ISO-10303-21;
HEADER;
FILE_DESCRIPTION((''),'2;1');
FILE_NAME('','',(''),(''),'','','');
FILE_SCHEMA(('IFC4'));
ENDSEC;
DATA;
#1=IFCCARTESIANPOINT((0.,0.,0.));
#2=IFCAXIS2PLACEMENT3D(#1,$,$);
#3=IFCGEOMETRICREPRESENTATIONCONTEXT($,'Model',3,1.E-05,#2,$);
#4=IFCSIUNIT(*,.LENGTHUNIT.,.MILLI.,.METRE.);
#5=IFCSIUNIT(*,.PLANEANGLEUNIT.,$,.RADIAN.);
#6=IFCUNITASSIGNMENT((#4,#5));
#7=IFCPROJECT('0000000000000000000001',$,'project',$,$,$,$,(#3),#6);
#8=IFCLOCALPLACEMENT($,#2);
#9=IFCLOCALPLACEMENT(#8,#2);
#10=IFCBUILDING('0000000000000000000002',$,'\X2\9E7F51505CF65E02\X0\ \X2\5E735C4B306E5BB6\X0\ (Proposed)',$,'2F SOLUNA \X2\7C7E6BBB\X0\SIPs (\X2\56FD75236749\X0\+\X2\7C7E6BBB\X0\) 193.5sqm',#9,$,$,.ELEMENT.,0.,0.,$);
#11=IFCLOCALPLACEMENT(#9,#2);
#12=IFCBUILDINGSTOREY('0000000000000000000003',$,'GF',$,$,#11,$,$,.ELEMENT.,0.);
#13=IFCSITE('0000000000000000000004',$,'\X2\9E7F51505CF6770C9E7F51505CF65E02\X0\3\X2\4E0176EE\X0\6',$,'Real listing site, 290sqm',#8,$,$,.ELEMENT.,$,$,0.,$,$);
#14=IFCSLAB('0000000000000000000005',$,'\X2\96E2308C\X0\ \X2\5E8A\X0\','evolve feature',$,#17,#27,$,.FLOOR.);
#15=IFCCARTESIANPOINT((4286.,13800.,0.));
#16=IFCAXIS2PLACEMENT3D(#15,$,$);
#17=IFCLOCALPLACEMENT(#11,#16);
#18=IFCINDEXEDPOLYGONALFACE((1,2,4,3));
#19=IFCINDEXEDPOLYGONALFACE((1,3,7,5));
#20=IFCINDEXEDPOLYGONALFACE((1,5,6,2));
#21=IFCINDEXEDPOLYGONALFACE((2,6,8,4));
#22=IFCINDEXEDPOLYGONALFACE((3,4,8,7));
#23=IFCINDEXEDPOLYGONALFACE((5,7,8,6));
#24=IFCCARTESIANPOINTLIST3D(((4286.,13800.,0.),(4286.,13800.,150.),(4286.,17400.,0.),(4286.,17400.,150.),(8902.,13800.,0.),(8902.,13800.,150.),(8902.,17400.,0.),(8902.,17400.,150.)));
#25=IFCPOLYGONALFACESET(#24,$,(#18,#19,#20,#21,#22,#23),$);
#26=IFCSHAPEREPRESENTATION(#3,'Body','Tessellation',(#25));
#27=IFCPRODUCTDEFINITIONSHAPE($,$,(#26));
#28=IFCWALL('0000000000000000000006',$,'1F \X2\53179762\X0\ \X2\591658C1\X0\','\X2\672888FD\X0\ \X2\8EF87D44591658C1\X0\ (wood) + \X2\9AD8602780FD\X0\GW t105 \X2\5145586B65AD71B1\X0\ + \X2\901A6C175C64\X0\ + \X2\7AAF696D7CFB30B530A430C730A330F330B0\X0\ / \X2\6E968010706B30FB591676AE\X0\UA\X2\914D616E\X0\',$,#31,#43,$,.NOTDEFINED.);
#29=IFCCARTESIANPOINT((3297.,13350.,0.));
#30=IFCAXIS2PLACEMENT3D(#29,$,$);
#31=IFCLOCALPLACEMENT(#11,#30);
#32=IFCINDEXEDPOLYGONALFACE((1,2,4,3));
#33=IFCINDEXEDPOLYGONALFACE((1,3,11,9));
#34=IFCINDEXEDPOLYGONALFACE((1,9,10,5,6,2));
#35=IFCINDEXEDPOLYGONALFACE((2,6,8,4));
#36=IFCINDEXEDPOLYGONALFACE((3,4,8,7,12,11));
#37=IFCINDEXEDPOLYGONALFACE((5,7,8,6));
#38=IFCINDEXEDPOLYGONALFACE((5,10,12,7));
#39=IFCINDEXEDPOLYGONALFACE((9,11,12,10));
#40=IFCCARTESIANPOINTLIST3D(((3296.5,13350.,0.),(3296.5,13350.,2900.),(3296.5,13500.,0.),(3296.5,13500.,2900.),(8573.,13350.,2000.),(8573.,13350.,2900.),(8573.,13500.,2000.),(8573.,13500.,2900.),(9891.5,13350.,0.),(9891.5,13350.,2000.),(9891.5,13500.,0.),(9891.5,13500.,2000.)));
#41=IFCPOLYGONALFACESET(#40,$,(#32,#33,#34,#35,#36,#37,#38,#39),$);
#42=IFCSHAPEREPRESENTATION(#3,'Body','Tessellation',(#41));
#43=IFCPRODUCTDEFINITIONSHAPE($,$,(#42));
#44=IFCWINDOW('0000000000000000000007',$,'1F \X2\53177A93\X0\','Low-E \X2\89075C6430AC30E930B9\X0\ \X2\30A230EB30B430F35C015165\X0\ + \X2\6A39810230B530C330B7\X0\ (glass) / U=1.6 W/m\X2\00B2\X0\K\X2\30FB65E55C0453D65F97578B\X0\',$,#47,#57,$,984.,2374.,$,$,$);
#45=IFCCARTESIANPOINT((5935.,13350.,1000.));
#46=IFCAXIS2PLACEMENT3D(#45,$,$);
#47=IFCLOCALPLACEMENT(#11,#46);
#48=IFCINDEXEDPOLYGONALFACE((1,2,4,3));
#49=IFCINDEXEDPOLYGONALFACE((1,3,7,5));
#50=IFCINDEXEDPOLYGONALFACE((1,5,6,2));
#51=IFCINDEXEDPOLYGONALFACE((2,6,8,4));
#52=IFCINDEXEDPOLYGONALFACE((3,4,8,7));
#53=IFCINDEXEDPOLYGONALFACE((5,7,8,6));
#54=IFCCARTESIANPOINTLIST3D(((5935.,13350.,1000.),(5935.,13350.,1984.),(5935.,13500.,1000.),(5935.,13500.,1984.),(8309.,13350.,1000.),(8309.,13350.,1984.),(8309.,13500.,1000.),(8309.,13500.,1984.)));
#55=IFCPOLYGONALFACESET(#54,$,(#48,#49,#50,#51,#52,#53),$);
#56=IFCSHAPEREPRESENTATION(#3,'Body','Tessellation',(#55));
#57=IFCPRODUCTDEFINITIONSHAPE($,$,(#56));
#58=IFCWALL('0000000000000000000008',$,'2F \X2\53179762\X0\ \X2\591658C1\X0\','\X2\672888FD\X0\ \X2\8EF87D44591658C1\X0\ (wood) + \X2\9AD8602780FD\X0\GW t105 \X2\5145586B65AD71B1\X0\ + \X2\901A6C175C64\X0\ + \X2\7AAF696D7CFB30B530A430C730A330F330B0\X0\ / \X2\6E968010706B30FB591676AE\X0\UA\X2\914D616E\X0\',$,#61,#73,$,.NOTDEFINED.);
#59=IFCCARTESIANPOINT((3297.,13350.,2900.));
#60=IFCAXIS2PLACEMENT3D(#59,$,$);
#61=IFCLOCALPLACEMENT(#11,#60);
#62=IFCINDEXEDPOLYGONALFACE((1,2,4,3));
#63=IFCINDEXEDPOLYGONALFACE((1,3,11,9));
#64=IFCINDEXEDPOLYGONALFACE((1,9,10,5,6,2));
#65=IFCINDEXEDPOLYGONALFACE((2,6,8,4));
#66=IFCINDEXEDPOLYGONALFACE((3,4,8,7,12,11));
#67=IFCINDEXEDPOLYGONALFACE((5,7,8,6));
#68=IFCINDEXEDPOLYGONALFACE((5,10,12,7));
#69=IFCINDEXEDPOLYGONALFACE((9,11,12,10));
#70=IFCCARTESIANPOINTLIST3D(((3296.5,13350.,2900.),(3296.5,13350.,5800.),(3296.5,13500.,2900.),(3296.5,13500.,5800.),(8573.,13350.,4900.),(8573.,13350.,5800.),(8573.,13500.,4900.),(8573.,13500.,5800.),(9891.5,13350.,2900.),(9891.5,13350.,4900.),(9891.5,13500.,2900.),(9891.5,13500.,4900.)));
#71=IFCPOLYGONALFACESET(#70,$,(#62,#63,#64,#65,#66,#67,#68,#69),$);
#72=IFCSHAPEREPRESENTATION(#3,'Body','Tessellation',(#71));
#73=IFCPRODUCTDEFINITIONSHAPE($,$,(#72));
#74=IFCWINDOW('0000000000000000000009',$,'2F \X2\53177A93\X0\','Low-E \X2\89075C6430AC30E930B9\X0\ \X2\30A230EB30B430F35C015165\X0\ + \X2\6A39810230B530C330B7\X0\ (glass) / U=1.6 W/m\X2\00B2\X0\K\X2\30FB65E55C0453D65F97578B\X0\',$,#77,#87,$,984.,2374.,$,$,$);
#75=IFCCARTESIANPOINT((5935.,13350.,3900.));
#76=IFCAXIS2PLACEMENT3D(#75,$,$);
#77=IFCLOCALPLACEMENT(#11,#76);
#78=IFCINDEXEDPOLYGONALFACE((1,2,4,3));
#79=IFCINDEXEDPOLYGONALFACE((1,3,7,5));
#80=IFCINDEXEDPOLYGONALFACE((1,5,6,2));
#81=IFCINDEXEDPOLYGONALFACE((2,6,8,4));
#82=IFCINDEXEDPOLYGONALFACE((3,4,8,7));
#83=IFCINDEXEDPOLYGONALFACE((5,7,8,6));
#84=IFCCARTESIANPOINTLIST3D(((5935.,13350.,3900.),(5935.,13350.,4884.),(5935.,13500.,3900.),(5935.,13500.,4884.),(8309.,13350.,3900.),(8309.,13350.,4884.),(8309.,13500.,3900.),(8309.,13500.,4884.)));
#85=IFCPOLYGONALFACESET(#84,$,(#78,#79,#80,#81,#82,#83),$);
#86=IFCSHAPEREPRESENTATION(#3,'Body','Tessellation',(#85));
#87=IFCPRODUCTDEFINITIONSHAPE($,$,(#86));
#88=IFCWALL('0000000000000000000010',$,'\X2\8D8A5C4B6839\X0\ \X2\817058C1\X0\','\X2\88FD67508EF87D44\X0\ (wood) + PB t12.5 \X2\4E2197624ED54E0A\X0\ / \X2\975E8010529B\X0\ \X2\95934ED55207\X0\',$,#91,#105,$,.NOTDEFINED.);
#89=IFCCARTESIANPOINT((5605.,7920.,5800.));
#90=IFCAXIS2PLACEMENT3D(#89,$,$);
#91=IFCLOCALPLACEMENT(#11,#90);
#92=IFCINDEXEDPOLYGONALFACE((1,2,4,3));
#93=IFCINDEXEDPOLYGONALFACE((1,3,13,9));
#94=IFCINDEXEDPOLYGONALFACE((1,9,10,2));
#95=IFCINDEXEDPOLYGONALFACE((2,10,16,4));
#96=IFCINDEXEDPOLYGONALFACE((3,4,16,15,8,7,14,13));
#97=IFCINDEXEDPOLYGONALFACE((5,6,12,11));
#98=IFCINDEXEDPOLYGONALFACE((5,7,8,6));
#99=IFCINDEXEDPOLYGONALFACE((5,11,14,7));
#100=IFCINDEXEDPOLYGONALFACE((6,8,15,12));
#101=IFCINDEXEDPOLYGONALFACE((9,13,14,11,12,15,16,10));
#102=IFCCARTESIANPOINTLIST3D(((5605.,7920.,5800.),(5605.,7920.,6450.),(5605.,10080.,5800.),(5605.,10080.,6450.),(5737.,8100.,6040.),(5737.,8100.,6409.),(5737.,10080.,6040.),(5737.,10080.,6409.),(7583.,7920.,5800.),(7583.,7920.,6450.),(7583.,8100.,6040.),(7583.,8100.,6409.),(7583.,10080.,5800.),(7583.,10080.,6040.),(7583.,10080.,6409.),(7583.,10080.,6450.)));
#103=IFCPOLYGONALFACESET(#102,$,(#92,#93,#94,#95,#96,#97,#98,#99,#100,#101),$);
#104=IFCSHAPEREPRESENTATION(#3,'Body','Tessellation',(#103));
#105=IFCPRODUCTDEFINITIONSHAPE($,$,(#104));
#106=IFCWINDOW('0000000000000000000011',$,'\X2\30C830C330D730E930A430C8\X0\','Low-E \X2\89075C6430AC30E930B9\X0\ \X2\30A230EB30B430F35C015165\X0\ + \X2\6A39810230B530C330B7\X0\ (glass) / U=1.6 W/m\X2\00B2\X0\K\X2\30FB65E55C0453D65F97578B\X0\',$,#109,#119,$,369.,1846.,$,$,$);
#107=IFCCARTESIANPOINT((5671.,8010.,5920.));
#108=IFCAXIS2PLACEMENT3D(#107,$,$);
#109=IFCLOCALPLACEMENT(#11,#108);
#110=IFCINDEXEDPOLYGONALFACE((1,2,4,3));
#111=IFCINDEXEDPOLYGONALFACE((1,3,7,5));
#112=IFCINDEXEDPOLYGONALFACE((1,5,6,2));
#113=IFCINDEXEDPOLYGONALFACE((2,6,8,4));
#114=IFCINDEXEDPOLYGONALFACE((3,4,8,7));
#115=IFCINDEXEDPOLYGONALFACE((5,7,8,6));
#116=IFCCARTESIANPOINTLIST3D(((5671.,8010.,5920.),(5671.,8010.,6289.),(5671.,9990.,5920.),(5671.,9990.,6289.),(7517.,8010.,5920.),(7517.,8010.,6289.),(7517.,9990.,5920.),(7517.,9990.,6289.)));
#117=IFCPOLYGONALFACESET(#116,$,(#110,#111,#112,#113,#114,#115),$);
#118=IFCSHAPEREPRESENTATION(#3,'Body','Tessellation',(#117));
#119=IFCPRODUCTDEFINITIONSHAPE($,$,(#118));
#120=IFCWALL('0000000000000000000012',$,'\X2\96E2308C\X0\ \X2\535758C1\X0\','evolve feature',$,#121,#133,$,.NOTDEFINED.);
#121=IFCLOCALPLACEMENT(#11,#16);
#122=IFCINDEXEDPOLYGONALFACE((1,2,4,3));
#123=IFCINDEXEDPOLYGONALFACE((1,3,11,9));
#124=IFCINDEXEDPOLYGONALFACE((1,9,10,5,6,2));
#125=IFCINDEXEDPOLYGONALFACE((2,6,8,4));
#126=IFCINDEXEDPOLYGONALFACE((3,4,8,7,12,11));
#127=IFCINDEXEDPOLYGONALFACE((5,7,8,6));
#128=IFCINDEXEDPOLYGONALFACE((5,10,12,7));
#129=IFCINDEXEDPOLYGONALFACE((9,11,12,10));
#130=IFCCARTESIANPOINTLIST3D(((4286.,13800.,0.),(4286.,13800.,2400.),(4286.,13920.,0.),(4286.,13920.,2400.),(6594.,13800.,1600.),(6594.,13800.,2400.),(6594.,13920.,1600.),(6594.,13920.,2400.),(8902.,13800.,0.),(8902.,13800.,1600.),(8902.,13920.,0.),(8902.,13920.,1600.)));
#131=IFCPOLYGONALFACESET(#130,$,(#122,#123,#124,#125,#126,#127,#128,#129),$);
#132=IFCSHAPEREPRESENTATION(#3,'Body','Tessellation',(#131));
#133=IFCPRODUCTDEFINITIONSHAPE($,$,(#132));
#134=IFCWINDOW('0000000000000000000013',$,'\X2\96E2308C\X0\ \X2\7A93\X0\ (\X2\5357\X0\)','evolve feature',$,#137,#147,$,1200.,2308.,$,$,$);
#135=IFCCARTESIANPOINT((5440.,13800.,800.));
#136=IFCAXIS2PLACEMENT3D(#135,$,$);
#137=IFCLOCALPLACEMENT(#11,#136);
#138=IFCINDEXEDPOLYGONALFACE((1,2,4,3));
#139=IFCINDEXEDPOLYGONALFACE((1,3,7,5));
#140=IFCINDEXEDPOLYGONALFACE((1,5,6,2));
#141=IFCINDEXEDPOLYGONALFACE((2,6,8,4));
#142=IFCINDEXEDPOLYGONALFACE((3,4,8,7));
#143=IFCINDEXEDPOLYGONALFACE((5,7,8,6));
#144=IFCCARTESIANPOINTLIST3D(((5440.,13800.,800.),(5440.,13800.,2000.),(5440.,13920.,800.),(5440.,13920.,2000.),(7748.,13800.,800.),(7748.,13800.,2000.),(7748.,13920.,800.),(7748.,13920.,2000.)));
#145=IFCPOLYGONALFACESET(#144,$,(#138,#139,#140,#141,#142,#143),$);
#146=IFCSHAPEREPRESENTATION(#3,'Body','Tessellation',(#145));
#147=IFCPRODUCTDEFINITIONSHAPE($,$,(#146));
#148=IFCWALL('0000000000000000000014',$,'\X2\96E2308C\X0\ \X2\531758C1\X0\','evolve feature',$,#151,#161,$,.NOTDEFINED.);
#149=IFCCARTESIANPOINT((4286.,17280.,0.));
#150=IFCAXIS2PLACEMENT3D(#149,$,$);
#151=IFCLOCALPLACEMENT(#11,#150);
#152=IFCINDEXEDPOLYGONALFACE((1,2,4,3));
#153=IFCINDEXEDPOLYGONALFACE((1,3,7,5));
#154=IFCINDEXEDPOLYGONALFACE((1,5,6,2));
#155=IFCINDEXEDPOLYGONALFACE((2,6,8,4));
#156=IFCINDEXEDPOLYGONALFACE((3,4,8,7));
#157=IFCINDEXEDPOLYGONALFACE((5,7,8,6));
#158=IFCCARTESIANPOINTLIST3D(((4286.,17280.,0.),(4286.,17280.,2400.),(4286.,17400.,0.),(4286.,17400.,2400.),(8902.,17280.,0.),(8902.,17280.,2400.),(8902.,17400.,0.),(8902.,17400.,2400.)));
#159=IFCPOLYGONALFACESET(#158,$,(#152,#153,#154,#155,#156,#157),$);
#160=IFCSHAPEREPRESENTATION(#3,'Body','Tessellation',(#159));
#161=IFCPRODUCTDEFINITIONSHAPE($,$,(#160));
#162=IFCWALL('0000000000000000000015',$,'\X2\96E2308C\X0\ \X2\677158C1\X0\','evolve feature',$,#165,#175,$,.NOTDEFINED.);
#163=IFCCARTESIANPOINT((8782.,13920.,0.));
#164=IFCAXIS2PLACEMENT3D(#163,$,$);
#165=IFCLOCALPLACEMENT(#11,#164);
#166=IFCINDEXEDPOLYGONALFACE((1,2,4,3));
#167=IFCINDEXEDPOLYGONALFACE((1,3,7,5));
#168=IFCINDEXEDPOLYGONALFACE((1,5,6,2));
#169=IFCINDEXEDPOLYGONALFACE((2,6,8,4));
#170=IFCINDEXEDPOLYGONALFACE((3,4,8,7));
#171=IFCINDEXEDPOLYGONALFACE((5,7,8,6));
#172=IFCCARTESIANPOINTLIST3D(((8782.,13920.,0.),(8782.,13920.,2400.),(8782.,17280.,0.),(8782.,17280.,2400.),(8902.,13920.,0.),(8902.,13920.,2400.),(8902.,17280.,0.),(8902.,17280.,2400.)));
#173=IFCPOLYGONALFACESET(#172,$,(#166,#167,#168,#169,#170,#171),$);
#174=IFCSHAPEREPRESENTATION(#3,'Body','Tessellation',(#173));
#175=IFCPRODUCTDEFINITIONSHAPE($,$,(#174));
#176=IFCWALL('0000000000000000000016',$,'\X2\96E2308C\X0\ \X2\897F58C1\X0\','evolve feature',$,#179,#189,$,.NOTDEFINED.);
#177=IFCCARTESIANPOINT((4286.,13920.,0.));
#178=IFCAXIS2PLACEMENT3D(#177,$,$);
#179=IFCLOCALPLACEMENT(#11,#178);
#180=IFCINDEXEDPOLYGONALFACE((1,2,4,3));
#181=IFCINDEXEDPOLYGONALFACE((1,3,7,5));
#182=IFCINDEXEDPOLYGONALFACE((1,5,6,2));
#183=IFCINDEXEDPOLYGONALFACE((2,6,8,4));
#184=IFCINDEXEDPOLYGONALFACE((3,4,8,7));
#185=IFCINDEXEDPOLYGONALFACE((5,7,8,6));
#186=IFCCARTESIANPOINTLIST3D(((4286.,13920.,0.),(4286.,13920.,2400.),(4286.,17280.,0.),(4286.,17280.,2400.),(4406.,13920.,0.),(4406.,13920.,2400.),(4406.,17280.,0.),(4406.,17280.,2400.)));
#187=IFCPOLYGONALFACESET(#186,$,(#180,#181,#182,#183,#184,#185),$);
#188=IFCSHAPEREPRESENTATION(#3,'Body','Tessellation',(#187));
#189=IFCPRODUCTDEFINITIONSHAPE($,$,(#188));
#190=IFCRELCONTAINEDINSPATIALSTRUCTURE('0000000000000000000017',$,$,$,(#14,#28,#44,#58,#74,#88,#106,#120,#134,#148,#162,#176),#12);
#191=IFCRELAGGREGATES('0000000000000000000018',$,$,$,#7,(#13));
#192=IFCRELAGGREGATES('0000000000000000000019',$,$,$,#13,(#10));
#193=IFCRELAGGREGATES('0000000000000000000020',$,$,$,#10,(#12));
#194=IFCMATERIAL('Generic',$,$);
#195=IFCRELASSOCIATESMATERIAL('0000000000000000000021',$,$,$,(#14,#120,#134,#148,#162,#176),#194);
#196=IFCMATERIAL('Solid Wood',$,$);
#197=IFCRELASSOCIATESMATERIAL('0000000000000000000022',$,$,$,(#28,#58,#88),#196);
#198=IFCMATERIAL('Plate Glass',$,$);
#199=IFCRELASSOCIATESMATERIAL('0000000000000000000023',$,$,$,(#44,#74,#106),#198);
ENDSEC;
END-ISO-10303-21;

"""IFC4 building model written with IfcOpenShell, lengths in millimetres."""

from ifc_helpers import new_model, si_unit, frame, frame_2d, origin, place, context, project, spatial, rectangle, extrude, material, element, fill, save


model = new_model("IFC4")

# Units and contexts
model_context = context("Model", 3, precision=1e-05, world=origin())
ifc_project = project(units=[si_unit("LENGTHUNIT", "METRE", prefix="MILLI"), si_unit("PLANEANGLEUNIT", "RADIAN")], contexts=[model_context])

# Site, building, storey
site_placement = place(None, origin())
site = spatial("IfcSite", under=ifc_project, at=site_placement, Name="鹿児島県鹿児島市3丁目6", ObjectType="Real listing site, 290sqm", CompositionType="ELEMENT", RefElevation=0.0)
building_placement = place(site_placement, origin())
building = spatial("IfcBuilding", under=site, at=building_placement, Name="鹿児島市 平屋の家 (Proposed)", ObjectType="2F SOLUNA 籾殻SIPs (国産杉+籾殻) 193.5sqm", CompositionType="ELEMENT", ElevationOfRefHeight=0.0, ElevationOfTerrain=0.0)
storey_placement = place(building_placement, origin())
storey = spatial("IfcBuildingStorey", under=building, at=storey_placement, Name="GF", CompositionType="ELEMENT", Elevation=0.0)

# Slab
ifc_material_1 = material(Name="Generic")
slab_placement = place(storey_placement, frame((4286.0, 13800.0, 0.0)))
element("IfcSlab", 1, at=slab_placement, inside=storey, material=ifc_material_1, Name="離れ 床", Description="evolve feature", PredefinedType="FLOOR", context=model_context, shape_type="SweptSolid", body=[
    extrude(rectangle(XDim=4616.0, YDim=3600.0, at=frame_2d((2308.0, 1800.0))), frame((4286.0, 13800.0, 0.0)), (0.0, 0.0, 1.0), 150.0),
])

# Wall, opening, window
ifc_material_2 = material(Name="Solid Wood")
wall_1_placement = place(storey_placement, frame((3297.0, 13350.0, 0.0)))
wall_1 = element("IfcWall", 2, at=wall_1_placement, inside=storey, material=ifc_material_2, Name="1F 北面 外壁", Description="木製 軸組外壁 (wood) + 高性能GW t105 充填断熱 + 通気層 + 窯業系サイディング / 準耐火・外皮UA配慮", PredefinedType="NOTDEFINED", context=model_context, shape_type="SweptSolid", body=[
    extrude(rectangle(XDim=6595.0, YDim=150.0, at=frame_2d((3297.0, 75.0))), frame((3297.0, 13350.0, 0.0)), (0.0, 0.0, 1.0), 2900.0),
])
opening_1_placement = place(storey_placement, frame((5935.0, 13350.0, 1000.0)))
opening_1 = element("IfcOpeningElement", 3, at=opening_1_placement, cuts=wall_1, PredefinedType="NOTDEFINED", context=model_context, shape_type="SweptSolid", body=[
    extrude(rectangle(XDim=2374.0, YDim=150.0, at=frame_2d((1187.0, 75.0))), frame((5935.0, 13350.0, 1000.0)), (0.0, 0.0, 1.0), 984.0),
])
ifc_material_3 = material(Name="Plate Glass")
window_1_placement = place(storey_placement, frame((5935.0, 13350.0, 1000.0)))
window_1 = element("IfcWindow", 4, at=window_1_placement, inside=storey, material=ifc_material_3, Name="1F 北窓", Description="Low-E 複層ガラス アルゴン封入 + 樹脂サッシ (glass) / U=1.6 W/m²K・日射取得型", OverallHeight=984.0, OverallWidth=2374.0, context=model_context, shape_type="SweptSolid", body=[
    extrude(rectangle(XDim=2374.0, YDim=150.0, at=frame_2d((1187.0, 75.0))), frame((5935.0, 13350.0, 1000.0)), (0.0, 0.0, 1.0), 984.0),
])
fill(opening_1, window_1)

# Wall, opening, window
wall_2_placement = place(storey_placement, frame((3297.0, 13350.0, 2900.0)))
wall_2 = element("IfcWall", 5, at=wall_2_placement, inside=storey, material=ifc_material_2, Name="2F 北面 外壁", Description="木製 軸組外壁 (wood) + 高性能GW t105 充填断熱 + 通気層 + 窯業系サイディング / 準耐火・外皮UA配慮", PredefinedType="NOTDEFINED", context=model_context, shape_type="SweptSolid", body=[
    extrude(rectangle(XDim=6595.0, YDim=150.0, at=frame_2d((3297.0, 75.0))), frame((3297.0, 13350.0, 2900.0)), (0.0, 0.0, 1.0), 2900.0),
])
opening_2_placement = place(storey_placement, frame((5935.0, 13350.0, 3900.0)))
opening_2 = element("IfcOpeningElement", 6, at=opening_2_placement, cuts=wall_2, PredefinedType="NOTDEFINED", context=model_context, shape_type="SweptSolid", body=[
    extrude(rectangle(XDim=2374.0, YDim=150.0, at=frame_2d((1187.0, 75.0))), frame((5935.0, 13350.0, 3900.0)), (0.0, 0.0, 1.0), 984.0),
])
window_2_placement = place(storey_placement, frame((5935.0, 13350.0, 3900.0)))
window_2 = element("IfcWindow", 7, at=window_2_placement, inside=storey, material=ifc_material_3, Name="2F 北窓", Description="Low-E 複層ガラス アルゴン封入 + 樹脂サッシ (glass) / U=1.6 W/m²K・日射取得型", OverallHeight=984.0, OverallWidth=2374.0, context=model_context, shape_type="SweptSolid", body=[
    extrude(rectangle(XDim=2374.0, YDim=150.0, at=frame_2d((1187.0, 75.0))), frame((5935.0, 13350.0, 3900.0)), (0.0, 0.0, 1.0), 984.0),
])
fill(opening_2, window_2)

# Walls, openings, windows
wall_3_placement = place(storey_placement, frame((5605.0, 7920.0, 5800.0)))
wall_3 = element("IfcWall", 8, at=wall_3_placement, inside=storey, material=ifc_material_2, Name="越屋根 腰壁", Description="製材軸組 (wood) + PB t12.5 両面仕上 / 非耐力 間仕切", PredefinedType="NOTDEFINED", context=model_context, shape_type="SweptSolid", body=[
    extrude(rectangle(XDim=1978.0, YDim=2160.0, at=frame_2d((989.0, 1080.0))), frame((5605.0, 7920.0, 5800.0)), (0.0, 0.0, 1.0), 650.0),
])
opening_3_placement = place(storey_placement, frame((5671.0, 8010.0, 5920.0)))
opening_3 = element("IfcOpeningElement", 9, at=opening_3_placement, cuts=wall_3, PredefinedType="NOTDEFINED", context=model_context, shape_type="SweptSolid", body=[
    extrude(rectangle(XDim=1846.0, YDim=1980.0, at=frame_2d((923.0, 990.0))), frame((5671.0, 8010.0, 5920.0)), (0.0, 0.0, 1.0), 369.0),
])
window_3_placement = place(storey_placement, frame((5671.0, 8010.0, 5920.0)))
window_3 = element("IfcWindow", 10, at=window_3_placement, inside=storey, material=ifc_material_3, Name="トップライト", Description="Low-E 複層ガラス アルゴン封入 + 樹脂サッシ (glass) / U=1.6 W/m²K・日射取得型", OverallHeight=369.0, OverallWidth=1846.0, context=model_context, shape_type="SweptSolid", body=[
    extrude(rectangle(XDim=1846.0, YDim=1980.0, at=frame_2d((923.0, 990.0))), frame((5671.0, 8010.0, 5920.0)), (0.0, 0.0, 1.0), 369.0),
])
fill(opening_3, window_3)
wall_4_placement = place(storey_placement, frame((4286.0, 13800.0, 0.0)))
wall_4 = element("IfcWall", 11, at=wall_4_placement, inside=storey, material=ifc_material_1, Name="離れ 南壁", Description="evolve feature", PredefinedType="NOTDEFINED", context=model_context, shape_type="SweptSolid", body=[
    extrude(rectangle(XDim=4616.0, YDim=120.0, at=frame_2d((2308.0, 60.0))), frame((4286.0, 13800.0, 0.0)), (0.0, 0.0, 1.0), 2400.0),
])
opening_4_placement = place(storey_placement, frame((5440.0, 13800.0, 800.0)))
opening_4 = element("IfcOpeningElement", 12, at=opening_4_placement, cuts=wall_4, PredefinedType="NOTDEFINED", context=model_context, shape_type="SweptSolid", body=[
    extrude(rectangle(XDim=2308.0, YDim=120.0, at=frame_2d((1154.0, 60.0))), frame((5440.0, 13800.0, 800.0)), (0.0, 0.0, 1.0), 1200.0),
])
window_4_placement = place(storey_placement, frame((5440.0, 13800.0, 800.0)))
window_4 = element("IfcWindow", 13, at=window_4_placement, inside=storey, material=ifc_material_1, Name="離れ 窓 (南)", Description="evolve feature", OverallHeight=1200.0, OverallWidth=2308.0, context=model_context, shape_type="SweptSolid", body=[
    extrude(rectangle(XDim=2308.0, YDim=120.0, at=frame_2d((1154.0, 60.0))), frame((5440.0, 13800.0, 800.0)), (0.0, 0.0, 1.0), 1200.0),
])
fill(opening_4, window_4)

# Walls
wall_5_placement = place(storey_placement, frame((4286.0, 17280.0, 0.0)))
element("IfcWall", 14, at=wall_5_placement, inside=storey, material=ifc_material_1, Name="離れ 北壁", Description="evolve feature", PredefinedType="NOTDEFINED", context=model_context, shape_type="SweptSolid", body=[
    extrude(rectangle(XDim=4616.0, YDim=120.0, at=frame_2d((2308.0, 60.0))), frame((4286.0, 17280.0, 0.0)), (0.0, 0.0, 1.0), 2400.0),
])
wall_6_placement = place(storey_placement, frame((8782.0, 13920.0, 0.0)))
element("IfcWall", 15, at=wall_6_placement, inside=storey, material=ifc_material_1, Name="離れ 東壁", Description="evolve feature", PredefinedType="NOTDEFINED", context=model_context, shape_type="SweptSolid", body=[
    extrude(rectangle(XDim=120.0, YDim=3360.0, at=frame_2d((60.0, 1680.0))), frame((8782.0, 13920.0, 0.0)), (0.0, 0.0, 1.0), 2400.0),
])
wall_7_placement = place(storey_placement, frame((4286.0, 13920.0, 0.0)))
element("IfcWall", 16, at=wall_7_placement, inside=storey, material=ifc_material_1, Name="離れ 西壁", Description="evolve feature", PredefinedType="NOTDEFINED", context=model_context, shape_type="SweptSolid", body=[
    extrude(rectangle(XDim=120.0, YDim=3360.0, at=frame_2d((60.0, 1680.0))), frame((4286.0, 13920.0, 0.0)), (0.0, 0.0, 1.0), 2400.0),
])

save(model, "model.ifc")
